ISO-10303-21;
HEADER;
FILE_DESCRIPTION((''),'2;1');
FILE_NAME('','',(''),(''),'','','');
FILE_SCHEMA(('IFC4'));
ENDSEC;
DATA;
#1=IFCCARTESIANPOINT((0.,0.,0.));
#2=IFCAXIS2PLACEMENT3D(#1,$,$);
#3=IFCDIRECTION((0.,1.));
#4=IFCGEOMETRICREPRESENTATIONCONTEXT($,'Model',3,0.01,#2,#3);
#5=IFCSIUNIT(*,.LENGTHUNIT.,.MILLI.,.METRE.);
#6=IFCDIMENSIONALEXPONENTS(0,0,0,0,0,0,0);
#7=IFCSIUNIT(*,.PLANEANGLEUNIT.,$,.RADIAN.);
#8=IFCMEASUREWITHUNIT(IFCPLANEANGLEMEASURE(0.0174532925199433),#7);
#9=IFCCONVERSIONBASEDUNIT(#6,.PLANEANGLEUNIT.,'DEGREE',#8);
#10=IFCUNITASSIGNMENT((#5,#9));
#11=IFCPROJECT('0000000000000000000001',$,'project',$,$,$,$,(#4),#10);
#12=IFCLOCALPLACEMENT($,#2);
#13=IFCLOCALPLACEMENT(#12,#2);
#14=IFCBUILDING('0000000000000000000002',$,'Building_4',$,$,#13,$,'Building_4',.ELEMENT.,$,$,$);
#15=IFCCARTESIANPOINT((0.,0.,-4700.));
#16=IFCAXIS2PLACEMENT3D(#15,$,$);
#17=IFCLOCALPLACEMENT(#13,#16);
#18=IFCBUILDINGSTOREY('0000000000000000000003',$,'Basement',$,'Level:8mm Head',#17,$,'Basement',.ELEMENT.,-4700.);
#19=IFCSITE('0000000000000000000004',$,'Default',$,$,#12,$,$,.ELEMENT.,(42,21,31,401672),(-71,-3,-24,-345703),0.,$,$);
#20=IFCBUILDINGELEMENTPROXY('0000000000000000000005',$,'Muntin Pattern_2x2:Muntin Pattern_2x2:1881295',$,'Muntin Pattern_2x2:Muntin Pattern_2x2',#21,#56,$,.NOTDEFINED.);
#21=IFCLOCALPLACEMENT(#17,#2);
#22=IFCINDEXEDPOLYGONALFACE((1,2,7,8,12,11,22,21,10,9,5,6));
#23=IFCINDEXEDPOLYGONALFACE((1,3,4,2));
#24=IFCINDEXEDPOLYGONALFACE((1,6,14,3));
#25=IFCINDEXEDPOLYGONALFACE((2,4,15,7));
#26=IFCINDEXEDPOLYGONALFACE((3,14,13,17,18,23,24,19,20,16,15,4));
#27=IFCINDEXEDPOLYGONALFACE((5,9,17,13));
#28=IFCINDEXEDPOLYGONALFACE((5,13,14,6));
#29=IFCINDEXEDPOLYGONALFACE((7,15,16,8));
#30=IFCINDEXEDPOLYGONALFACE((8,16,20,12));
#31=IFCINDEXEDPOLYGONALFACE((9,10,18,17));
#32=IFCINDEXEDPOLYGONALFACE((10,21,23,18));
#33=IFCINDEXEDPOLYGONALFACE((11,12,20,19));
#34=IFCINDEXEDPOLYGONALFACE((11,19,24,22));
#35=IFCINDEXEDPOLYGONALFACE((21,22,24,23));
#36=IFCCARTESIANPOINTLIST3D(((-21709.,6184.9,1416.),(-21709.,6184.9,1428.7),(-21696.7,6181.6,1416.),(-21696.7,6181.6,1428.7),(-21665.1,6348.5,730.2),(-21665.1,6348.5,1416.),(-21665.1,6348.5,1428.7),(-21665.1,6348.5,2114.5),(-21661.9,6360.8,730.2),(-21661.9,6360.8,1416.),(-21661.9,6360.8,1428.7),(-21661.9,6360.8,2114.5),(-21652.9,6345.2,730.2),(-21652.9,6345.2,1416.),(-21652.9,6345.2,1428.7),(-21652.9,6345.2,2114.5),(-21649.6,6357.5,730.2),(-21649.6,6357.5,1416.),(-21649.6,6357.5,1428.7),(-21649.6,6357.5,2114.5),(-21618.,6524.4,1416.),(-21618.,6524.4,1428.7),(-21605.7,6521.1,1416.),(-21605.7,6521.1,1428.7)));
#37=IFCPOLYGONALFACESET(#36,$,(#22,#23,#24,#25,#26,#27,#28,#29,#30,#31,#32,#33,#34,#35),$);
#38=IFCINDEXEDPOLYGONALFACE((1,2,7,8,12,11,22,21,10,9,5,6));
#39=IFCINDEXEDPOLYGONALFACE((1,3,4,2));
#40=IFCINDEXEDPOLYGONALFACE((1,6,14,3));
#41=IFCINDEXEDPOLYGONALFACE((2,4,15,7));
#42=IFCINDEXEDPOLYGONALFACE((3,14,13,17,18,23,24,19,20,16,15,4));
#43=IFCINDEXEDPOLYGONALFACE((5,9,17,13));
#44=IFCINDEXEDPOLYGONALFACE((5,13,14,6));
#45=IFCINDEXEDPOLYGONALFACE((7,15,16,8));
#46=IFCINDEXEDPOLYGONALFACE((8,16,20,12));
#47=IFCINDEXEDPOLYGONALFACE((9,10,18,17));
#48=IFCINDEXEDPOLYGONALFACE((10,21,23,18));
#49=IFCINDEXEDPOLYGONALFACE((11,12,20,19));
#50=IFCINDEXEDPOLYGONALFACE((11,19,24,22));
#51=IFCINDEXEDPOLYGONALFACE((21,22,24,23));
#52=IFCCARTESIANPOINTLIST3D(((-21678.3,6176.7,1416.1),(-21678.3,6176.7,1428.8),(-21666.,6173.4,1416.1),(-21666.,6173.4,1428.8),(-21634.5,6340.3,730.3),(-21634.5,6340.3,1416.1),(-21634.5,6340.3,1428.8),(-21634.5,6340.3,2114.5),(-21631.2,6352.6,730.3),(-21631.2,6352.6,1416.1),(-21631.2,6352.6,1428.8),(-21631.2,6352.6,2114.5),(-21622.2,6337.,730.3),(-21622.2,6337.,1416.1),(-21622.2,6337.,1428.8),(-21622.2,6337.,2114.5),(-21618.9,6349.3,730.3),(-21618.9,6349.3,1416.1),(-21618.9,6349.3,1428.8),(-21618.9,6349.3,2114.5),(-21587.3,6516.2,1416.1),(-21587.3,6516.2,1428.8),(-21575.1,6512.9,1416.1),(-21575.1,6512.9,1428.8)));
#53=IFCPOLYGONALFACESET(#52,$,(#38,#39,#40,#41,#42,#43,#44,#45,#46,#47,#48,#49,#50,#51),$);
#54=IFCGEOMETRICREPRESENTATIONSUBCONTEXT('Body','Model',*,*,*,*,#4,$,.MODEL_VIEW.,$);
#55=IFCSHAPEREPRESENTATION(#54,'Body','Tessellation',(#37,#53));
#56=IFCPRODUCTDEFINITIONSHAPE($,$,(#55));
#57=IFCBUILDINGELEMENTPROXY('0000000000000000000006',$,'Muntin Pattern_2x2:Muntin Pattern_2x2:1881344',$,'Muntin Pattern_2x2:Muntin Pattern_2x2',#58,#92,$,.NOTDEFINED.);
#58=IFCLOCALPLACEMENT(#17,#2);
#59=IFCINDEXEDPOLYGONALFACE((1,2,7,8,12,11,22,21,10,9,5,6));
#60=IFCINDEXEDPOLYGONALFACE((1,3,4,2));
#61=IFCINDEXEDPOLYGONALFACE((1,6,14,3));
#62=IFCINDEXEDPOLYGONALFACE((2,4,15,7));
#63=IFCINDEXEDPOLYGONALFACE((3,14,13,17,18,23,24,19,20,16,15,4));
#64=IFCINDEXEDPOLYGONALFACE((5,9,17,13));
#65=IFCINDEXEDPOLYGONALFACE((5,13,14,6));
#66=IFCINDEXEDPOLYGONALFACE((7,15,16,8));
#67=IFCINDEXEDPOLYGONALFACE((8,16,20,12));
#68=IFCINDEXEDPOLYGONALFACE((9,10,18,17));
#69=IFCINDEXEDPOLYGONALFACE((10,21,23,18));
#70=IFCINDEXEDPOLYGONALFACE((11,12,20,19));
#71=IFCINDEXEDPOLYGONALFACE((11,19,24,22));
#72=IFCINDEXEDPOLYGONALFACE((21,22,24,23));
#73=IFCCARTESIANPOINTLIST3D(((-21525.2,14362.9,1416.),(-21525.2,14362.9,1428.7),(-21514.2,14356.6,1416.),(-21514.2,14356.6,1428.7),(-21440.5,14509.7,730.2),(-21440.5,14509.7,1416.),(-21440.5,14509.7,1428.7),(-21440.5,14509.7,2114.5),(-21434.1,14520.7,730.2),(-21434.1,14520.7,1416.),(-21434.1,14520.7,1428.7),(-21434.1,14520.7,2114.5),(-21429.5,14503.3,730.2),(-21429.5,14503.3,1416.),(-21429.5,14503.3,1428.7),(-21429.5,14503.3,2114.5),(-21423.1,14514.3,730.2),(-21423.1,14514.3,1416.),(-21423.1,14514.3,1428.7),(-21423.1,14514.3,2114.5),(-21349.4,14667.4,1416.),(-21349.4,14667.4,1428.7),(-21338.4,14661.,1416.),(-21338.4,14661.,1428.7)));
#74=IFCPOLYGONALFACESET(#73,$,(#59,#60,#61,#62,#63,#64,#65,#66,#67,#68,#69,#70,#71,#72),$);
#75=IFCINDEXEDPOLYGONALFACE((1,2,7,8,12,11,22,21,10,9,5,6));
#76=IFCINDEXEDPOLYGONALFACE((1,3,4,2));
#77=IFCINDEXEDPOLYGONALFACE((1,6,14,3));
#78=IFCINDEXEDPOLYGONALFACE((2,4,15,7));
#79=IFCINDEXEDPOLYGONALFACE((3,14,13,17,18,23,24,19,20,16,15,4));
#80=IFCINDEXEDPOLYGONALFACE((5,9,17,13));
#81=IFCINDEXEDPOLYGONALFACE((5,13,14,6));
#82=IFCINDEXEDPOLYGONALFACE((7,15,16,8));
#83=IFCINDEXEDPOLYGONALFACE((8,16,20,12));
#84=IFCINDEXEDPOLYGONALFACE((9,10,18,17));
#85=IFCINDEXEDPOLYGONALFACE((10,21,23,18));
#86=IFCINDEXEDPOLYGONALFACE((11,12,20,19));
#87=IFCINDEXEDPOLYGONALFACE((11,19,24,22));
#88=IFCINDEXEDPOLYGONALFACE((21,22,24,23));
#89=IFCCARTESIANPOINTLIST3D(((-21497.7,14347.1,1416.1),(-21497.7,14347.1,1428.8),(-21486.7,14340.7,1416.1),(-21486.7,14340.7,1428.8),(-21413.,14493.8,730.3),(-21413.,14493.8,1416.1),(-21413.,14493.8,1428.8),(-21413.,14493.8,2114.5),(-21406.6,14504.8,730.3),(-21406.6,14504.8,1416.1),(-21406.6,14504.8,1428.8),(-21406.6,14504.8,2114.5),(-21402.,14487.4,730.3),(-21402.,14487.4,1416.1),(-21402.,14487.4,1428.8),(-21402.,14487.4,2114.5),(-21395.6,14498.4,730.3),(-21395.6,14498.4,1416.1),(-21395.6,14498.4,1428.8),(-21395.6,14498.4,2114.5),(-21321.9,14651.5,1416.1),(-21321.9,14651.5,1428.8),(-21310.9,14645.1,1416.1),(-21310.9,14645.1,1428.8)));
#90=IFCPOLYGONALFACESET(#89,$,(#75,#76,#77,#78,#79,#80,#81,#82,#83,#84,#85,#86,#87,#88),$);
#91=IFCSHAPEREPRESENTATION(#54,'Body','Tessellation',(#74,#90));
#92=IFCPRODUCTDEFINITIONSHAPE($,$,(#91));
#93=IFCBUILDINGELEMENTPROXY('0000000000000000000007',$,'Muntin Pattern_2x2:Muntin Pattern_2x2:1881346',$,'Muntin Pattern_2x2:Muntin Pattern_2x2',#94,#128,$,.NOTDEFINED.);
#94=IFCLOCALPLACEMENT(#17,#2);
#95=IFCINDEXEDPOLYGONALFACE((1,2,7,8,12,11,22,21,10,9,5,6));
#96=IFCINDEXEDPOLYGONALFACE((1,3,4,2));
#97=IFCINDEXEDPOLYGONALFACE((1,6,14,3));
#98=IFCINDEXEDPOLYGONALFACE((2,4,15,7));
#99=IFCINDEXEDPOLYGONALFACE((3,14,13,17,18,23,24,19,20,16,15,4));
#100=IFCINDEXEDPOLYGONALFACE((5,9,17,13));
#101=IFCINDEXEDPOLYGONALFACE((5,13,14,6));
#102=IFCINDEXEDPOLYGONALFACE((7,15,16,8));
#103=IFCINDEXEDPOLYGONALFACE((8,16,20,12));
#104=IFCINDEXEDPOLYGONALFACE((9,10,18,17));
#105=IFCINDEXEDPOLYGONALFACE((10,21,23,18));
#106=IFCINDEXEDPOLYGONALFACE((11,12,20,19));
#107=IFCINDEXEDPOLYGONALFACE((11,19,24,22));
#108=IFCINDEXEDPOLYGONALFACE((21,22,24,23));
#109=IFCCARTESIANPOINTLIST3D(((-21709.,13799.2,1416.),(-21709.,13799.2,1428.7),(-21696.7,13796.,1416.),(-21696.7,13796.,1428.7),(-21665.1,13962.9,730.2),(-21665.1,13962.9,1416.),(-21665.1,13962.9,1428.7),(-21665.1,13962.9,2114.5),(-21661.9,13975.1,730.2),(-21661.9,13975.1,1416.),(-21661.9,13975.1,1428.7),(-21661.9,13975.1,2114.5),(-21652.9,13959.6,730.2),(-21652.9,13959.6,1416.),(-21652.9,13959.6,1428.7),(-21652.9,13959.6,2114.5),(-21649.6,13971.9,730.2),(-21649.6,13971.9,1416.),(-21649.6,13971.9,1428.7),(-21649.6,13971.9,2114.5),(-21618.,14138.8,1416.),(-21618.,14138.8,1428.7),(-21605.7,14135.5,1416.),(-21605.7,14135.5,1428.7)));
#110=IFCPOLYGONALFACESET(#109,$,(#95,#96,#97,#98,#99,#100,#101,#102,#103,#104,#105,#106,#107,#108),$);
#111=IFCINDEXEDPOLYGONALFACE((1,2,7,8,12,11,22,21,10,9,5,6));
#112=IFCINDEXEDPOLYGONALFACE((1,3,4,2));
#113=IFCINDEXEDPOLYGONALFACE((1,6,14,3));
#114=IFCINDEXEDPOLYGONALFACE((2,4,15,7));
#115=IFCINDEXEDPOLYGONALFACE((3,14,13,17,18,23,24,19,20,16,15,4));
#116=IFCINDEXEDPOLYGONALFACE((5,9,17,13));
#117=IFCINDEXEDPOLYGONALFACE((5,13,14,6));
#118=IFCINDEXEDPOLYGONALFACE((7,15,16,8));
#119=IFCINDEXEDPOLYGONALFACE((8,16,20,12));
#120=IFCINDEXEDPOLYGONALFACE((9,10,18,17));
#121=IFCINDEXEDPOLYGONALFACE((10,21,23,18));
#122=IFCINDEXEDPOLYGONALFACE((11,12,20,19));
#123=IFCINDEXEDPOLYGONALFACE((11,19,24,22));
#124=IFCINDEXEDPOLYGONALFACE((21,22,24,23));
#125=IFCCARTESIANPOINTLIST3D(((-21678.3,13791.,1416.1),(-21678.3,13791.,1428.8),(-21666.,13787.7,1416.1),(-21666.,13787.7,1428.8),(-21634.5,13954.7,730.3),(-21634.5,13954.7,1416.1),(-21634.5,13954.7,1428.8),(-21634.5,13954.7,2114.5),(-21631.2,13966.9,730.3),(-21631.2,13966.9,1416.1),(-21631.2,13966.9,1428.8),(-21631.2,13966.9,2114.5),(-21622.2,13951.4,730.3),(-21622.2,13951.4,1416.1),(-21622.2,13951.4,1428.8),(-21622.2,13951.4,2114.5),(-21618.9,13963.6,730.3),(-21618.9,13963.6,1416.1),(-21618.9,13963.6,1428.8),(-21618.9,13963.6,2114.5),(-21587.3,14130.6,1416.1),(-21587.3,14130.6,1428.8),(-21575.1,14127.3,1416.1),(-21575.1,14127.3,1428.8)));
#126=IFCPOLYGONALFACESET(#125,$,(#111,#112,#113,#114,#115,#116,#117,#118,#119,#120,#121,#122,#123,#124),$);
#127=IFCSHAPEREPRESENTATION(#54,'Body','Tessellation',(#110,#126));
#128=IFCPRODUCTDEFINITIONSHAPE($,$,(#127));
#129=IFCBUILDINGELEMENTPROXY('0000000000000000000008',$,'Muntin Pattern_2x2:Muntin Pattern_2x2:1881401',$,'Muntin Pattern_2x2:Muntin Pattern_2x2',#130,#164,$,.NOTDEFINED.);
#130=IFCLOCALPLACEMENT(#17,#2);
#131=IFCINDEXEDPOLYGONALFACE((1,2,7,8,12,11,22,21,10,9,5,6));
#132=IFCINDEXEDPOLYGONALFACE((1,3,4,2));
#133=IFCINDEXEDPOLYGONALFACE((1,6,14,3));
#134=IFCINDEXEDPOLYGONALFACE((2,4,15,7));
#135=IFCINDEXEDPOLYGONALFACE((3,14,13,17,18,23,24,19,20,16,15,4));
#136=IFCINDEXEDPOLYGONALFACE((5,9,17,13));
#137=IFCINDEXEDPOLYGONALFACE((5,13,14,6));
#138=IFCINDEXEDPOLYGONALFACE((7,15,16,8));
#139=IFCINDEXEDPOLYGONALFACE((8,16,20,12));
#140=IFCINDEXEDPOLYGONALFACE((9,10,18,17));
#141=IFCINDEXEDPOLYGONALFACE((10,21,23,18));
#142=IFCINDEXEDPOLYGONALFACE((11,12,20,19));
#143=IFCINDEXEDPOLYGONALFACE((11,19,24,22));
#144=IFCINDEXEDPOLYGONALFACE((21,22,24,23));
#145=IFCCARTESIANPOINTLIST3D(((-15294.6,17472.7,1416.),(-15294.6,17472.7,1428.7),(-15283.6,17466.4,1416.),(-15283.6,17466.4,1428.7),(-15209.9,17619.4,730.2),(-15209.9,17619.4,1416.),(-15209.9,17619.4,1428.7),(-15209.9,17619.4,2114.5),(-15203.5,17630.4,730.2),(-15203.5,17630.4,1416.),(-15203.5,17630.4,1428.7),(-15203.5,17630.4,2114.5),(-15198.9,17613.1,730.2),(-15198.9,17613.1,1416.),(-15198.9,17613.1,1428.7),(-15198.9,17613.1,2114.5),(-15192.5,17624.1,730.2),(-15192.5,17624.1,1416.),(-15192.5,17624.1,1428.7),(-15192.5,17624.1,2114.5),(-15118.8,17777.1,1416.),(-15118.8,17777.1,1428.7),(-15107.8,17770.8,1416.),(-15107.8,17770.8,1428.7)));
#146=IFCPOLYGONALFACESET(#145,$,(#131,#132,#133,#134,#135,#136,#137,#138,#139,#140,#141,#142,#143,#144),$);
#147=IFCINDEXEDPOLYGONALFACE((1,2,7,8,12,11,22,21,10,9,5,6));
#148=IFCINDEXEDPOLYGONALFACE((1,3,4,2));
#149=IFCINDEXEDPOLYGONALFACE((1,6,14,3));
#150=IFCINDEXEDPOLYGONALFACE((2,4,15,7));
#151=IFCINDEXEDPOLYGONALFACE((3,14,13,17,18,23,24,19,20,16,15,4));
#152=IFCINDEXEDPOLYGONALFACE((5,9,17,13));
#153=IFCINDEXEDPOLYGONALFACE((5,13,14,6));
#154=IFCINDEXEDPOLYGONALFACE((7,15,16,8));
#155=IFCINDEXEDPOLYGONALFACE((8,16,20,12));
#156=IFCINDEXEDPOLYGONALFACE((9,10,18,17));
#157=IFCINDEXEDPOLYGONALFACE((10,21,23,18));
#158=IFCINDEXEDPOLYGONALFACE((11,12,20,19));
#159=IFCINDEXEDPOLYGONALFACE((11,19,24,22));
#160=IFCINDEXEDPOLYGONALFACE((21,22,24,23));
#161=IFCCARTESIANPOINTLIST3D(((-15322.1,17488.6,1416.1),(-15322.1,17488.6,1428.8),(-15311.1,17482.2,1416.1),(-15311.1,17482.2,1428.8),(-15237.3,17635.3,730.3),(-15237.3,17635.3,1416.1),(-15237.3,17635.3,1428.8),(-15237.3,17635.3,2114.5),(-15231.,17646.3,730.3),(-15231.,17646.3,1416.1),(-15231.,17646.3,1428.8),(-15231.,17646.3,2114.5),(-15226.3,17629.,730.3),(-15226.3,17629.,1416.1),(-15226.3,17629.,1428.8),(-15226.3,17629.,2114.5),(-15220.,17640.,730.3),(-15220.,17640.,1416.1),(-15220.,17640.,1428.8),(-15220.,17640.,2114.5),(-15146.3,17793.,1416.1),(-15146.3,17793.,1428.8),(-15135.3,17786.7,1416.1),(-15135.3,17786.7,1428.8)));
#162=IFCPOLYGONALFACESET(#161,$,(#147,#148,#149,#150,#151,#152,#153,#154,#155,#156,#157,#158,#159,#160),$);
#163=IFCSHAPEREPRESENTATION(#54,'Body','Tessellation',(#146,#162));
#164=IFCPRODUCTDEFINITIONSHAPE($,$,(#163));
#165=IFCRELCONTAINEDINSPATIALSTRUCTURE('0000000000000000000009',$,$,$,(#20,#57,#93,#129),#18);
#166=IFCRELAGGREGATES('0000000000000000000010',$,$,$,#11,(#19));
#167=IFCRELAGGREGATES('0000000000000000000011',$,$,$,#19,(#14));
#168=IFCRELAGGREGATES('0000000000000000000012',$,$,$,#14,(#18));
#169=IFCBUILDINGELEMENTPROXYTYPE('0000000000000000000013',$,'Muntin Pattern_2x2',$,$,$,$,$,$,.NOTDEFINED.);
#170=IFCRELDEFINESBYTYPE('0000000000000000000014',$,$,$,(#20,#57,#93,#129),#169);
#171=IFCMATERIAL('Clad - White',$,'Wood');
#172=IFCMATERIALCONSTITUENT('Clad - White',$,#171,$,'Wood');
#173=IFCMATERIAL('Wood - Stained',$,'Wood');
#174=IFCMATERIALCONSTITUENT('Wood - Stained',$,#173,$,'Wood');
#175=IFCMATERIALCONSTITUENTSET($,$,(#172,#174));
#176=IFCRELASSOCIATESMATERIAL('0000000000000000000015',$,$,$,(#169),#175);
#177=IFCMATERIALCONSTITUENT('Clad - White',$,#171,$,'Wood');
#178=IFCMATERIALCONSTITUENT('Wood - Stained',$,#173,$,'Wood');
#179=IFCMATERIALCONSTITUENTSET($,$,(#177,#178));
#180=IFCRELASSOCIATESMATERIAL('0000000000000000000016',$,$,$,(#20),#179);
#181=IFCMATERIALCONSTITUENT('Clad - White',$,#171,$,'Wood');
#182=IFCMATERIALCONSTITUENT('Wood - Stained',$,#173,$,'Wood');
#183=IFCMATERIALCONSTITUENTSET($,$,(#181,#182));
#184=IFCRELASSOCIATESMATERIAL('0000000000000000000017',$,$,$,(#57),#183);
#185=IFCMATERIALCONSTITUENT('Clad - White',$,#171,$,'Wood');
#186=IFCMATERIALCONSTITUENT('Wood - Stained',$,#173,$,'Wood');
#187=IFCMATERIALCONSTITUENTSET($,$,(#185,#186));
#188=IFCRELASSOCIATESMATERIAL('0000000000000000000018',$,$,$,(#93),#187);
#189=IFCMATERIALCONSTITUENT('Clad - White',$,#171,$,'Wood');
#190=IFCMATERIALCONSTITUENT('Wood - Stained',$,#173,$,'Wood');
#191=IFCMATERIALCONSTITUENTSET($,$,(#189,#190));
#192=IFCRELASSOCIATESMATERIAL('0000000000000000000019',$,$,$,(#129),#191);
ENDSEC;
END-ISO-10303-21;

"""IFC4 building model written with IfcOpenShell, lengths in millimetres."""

from ifc_helpers import new_model, entity, si_unit, converted_unit, direction, frame, origin, place, context, subcontext, project, spatial, indexed_curve, outline, extrude, source, transform, mapped, material, constituent, constituent_set, type_object, type_shapes, element, save


model = new_model("IFC4")

# Units and contexts
model_context = context("Model", 3, precision=0.01, world=origin(), true_north=direction((0.0, 1.0)))
body_context = subcontext(model_context, "Body", "Model", "MODEL_VIEW")
ifc_project = project(units=[si_unit("LENGTHUNIT", "METRE", prefix="MILLI"), converted_unit("PLANEANGLEUNIT", "DEGREE", entity("IfcPlaneAngleMeasure", 0.0174532925199433), si_unit("PLANEANGLEUNIT", "RADIAN"), dimensions=[0, 0, 0, 0, 0, 0, 0])], contexts=[model_context])

# Site, building, storey
site_placement = place(None, origin())
site = spatial("IfcSite", under=ifc_project, at=site_placement, Name="Default", CompositionType="ELEMENT", RefLatitude=(42, 21, 31, 401672), RefLongitude=(-71, -3, -24, -345703), RefElevation=0.0)
building_placement = place(site_placement, origin())
building = spatial("IfcBuilding", under=site, at=building_placement, Name="Building_4", LongName="Building_4", CompositionType="ELEMENT")
storey_placement = place(building_placement, frame((0.0, 0.0, -4700.0)))
storey = spatial("IfcBuildingStorey", under=building, at=storey_placement, Name="Basement", ObjectType="Level:8mm Head", LongName="Basement", CompositionType="ELEMENT", Elevation=-4700.0)

# Building element proxies
ifc_material_1 = material(Name="Clad - White", Category="Wood")
ifc_material_2 = material(Name="Wood - Stained", Category="Wood")
ifc_constituent_1 = constituent(ifc_material_1, Name="Clad - White", Category="Wood")
ifc_constituent_2 = constituent(ifc_material_2, Name="Wood - Stained", Category="Wood")
ifc_constituent_set_1 = constituent_set(constituents=[ifc_constituent_1, ifc_constituent_2])
building_element_proxy_type_1 = type_object("IfcBuildingElementProxyType", Name="Muntin Pattern_2x2", PredefinedType="NOTDEFINED", material=ifc_constituent_set_1)
shared_shape_1 = source(origin(), body_context, "Body", "SweptSolid", [
    extrude(outline(indexed_curve([(6.4, -6.4), (692.1, -6.4), (692.1, 6.3), (6.4, 6.3), (6.4, 175.8), (-6.3, 175.8), (-6.3, 6.3), (-692.2, 6.3), (-692.2, -6.4), (-6.3, -6.4), (-6.3, -175.8), (6.4, -175.8), (6.4, -6.4)], self_intersect=False)), frame((0.0, -22.2, 692.1), z_axis=(0.0, 1.0, 0.0), x_axis=(0.0, 0.0, 1.0)), (0.0, 0.0, 1.0), 12.7),
    extrude(outline(indexed_curve([(6.4, -6.4), (692.1, -6.4), (692.1, 6.3), (6.4, 6.3), (6.4, 175.8), (-6.3, 175.8), (-6.3, 6.3), (-692.1, 6.3), (-692.1, -6.4), (-6.3, -6.4), (-6.3, -175.8), (6.4, -175.8), (6.4, -6.4)], self_intersect=False)), frame((0.0, 9.5, 692.1), z_axis=(0.0, 1.0, 0.0), x_axis=(0.0, 0.0, 1.0)), (0.0, 0.0, 1.0), 12.7),
])
type_shapes(building_element_proxy_type_1, [shared_shape_1])
ifc_constituent_3 = constituent(ifc_material_1, Name="Clad - White", Category="Wood")
ifc_constituent_4 = constituent(ifc_material_2, Name="Wood - Stained", Category="Wood")
ifc_constituent_set_2 = constituent_set(constituents=[ifc_constituent_3, ifc_constituent_4])
proxy_1_placement = place(storey_placement, frame((-21642.0, 6348.9, 730.3), z_axis=(0.0, 0.0, 1.0), x_axis=(-0.258819, -0.965926, 0.0)))
element("IfcBuildingElementProxy", 1, at=proxy_1_placement, inside=storey, type_object=building_element_proxy_type_1, material=ifc_constituent_set_2, Name="Muntin Pattern_2x2:Muntin Pattern_2x2:1881295", ObjectType="Muntin Pattern_2x2:Muntin Pattern_2x2", PredefinedType="NOTDEFINED", context=body_context, shape_type="MappedRepresentation", body=[
    mapped(shared_shape_1, transform((0.0, 0.0, 0.0), scale=1.0)),
])
ifc_constituent_5 = constituent(ifc_material_1, Name="Clad - White", Category="Wood")
ifc_constituent_6 = constituent(ifc_material_2, Name="Wood - Stained", Category="Wood")
ifc_constituent_set_3 = constituent_set(constituents=[ifc_constituent_5, ifc_constituent_6])
proxy_2_placement = place(storey_placement, frame((-21418.0, 14504.0, 730.3), z_axis=(0.0, 0.0, 1.0), x_axis=(-0.5, -0.866025, 0.0)))
element("IfcBuildingElementProxy", 2, at=proxy_2_placement, inside=storey, type_object=building_element_proxy_type_1, material=ifc_constituent_set_3, Name="Muntin Pattern_2x2:Muntin Pattern_2x2:1881344", ObjectType="Muntin Pattern_2x2:Muntin Pattern_2x2", PredefinedType="NOTDEFINED", context=body_context, shape_type="MappedRepresentation", body=[
    mapped(shared_shape_1, transform((0.0, 0.0, 0.0), scale=1.0)),
])
ifc_constituent_7 = constituent(ifc_material_1, Name="Clad - White", Category="Wood")
ifc_constituent_8 = constituent(ifc_material_2, Name="Wood - Stained", Category="Wood")
ifc_constituent_set_4 = constituent_set(constituents=[ifc_constituent_7, ifc_constituent_8])
proxy_3_placement = place(storey_placement, frame((-21642.0, 13963.3, 730.3), z_axis=(0.0, 0.0, 1.0), x_axis=(-0.258819, -0.965926, 0.0)))
element("IfcBuildingElementProxy", 3, at=proxy_3_placement, inside=storey, type_object=building_element_proxy_type_1, material=ifc_constituent_set_4, Name="Muntin Pattern_2x2:Muntin Pattern_2x2:1881346", ObjectType="Muntin Pattern_2x2:Muntin Pattern_2x2", PredefinedType="NOTDEFINED", context=body_context, shape_type="MappedRepresentation", body=[
    mapped(shared_shape_1, transform((0.0, 0.0, 0.0), scale=1.0)),
])
ifc_constituent_9 = constituent(ifc_material_1, Name="Clad - White", Category="Wood")
ifc_constituent_10 = constituent(ifc_material_2, Name="Wood - Stained", Category="Wood")
ifc_constituent_set_5 = constituent_set(constituents=[ifc_constituent_9, ifc_constituent_10])
proxy_4_placement = place(storey_placement, frame((-15214.9, 17629.7, 730.3), z_axis=(0.0, 0.0, 1.0), x_axis=(0.5, 0.866025, 0.0)))
element("IfcBuildingElementProxy", 4, at=proxy_4_placement, inside=storey, type_object=building_element_proxy_type_1, material=ifc_constituent_set_5, Name="Muntin Pattern_2x2:Muntin Pattern_2x2:1881401", ObjectType="Muntin Pattern_2x2:Muntin Pattern_2x2", PredefinedType="NOTDEFINED", context=body_context, shape_type="MappedRepresentation", body=[
    mapped(shared_shape_1, transform((0.0, 0.0, 0.0), scale=1.0)),
])

save(model, "model.ifc")
